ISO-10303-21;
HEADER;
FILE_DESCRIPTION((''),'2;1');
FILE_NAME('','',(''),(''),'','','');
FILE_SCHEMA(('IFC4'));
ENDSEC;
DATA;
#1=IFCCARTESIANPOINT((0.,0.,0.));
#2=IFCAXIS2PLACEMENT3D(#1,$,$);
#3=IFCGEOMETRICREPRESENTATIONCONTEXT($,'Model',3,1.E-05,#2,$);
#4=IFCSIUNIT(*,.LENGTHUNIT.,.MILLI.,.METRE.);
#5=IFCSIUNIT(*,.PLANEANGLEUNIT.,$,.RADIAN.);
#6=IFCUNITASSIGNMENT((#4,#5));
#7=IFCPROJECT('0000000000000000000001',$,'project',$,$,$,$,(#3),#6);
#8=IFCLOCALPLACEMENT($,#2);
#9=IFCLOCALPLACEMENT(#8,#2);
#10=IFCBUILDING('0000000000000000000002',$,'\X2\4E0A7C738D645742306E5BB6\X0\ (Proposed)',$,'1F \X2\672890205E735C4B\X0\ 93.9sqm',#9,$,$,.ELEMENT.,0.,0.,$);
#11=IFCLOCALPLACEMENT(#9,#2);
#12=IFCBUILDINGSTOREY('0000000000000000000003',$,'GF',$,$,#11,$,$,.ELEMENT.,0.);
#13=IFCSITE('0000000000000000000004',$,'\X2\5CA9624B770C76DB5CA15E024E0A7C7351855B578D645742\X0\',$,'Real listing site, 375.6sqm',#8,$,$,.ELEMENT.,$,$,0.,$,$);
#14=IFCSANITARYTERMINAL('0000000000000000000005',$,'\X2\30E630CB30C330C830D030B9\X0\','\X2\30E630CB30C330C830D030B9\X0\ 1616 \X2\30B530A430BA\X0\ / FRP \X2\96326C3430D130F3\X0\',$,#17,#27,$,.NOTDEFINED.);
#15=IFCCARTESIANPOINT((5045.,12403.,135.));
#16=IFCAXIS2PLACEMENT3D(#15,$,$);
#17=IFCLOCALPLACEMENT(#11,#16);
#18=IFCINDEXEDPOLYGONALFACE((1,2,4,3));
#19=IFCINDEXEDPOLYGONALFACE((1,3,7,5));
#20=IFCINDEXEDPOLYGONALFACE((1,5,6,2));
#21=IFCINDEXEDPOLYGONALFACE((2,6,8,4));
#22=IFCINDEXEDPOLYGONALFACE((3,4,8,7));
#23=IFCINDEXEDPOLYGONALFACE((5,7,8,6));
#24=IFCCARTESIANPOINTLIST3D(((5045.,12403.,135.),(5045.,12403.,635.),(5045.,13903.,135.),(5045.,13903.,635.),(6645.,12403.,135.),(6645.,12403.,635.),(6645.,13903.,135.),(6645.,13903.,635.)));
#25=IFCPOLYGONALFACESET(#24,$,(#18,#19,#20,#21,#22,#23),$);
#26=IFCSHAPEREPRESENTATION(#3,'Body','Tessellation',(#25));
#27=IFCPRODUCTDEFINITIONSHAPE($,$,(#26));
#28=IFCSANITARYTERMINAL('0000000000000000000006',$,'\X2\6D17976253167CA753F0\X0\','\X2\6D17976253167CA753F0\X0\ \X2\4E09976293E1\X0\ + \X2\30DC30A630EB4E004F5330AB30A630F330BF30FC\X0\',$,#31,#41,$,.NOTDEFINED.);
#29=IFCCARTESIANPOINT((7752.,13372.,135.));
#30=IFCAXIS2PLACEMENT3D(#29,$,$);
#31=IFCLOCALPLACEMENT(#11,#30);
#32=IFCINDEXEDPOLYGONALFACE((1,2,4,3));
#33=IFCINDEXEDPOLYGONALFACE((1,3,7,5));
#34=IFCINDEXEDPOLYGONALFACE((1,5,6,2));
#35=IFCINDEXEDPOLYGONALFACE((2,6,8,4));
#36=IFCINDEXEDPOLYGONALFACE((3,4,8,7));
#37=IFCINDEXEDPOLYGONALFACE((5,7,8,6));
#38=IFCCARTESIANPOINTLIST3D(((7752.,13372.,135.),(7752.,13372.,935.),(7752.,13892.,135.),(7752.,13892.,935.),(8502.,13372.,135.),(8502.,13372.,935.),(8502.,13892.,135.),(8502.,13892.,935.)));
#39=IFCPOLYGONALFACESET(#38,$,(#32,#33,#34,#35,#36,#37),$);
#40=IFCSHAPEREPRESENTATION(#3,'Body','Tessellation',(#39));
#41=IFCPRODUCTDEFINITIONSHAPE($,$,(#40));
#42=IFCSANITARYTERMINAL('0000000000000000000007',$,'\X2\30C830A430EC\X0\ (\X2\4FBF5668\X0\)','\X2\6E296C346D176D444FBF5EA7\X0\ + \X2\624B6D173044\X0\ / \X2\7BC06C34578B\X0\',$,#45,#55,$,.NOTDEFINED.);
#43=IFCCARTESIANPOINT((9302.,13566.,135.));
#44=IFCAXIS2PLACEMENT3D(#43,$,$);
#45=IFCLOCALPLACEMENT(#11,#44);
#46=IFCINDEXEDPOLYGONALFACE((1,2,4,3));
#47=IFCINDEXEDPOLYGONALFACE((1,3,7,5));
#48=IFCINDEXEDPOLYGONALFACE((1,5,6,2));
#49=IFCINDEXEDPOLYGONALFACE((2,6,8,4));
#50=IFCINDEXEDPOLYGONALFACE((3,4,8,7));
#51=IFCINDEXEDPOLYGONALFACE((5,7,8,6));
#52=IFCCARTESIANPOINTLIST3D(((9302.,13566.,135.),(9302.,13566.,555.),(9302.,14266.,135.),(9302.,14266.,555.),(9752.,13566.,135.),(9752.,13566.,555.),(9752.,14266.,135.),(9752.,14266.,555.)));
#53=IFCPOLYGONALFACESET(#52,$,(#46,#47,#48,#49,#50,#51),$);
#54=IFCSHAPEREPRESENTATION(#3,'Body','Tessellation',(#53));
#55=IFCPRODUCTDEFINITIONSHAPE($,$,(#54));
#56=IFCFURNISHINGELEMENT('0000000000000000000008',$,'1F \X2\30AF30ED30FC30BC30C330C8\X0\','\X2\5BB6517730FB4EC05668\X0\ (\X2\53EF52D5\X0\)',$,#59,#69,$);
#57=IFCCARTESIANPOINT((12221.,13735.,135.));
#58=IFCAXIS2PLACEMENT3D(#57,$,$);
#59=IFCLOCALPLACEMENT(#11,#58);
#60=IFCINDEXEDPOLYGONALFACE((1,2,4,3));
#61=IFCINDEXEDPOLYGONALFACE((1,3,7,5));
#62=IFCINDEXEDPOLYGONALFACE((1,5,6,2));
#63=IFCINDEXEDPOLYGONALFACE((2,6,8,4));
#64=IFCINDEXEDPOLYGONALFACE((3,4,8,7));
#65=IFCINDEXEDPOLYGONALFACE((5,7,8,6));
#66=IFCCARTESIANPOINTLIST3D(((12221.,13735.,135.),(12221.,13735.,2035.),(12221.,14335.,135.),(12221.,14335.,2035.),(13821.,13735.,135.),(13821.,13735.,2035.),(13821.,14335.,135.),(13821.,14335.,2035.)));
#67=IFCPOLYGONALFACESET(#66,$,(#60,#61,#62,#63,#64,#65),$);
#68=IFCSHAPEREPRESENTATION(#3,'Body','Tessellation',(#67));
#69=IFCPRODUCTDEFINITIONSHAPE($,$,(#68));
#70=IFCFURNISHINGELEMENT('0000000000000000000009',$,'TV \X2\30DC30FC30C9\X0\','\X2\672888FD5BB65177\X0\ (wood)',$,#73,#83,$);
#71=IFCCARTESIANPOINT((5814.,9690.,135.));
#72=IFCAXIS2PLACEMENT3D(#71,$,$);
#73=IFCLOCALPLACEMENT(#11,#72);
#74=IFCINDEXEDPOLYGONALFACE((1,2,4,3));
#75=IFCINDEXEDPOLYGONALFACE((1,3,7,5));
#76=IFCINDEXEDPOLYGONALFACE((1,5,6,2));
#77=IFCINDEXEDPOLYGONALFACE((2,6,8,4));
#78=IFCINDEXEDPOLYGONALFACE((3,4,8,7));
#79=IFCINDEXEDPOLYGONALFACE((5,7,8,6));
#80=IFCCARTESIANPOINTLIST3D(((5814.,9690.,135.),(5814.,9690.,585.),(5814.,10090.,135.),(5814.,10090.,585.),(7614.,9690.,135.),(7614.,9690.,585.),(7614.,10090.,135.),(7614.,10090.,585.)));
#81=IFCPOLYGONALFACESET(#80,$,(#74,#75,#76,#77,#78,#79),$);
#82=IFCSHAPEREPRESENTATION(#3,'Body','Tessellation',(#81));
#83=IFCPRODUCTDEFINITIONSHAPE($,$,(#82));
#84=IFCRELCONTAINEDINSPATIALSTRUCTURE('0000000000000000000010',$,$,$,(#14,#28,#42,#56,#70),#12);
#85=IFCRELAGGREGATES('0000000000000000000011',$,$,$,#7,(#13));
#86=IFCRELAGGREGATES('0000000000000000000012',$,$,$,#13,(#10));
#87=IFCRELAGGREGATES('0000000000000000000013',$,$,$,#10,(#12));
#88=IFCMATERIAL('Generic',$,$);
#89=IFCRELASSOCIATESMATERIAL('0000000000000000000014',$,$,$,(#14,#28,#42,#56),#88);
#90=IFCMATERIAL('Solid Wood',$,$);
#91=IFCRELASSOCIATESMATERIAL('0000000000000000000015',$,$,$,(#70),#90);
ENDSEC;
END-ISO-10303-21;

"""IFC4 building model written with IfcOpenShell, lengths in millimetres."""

from ifc_helpers import new_model, si_unit, frame, frame_2d, origin, place, context, project, spatial, rectangle, extrude, material, element, save


model = new_model("IFC4")

# Units and contexts
model_context = context("Model", 3, precision=1e-05, world=origin())
ifc_project = project(units=[si_unit("LENGTHUNIT", "METRE", prefix="MILLI"), si_unit("PLANEANGLEUNIT", "RADIAN")], contexts=[model_context])

# Site, building, storey
site_placement = place(None, origin())
site = spatial("IfcSite", under=ifc_project, at=site_placement, Name="岩手県盛岡市上米内字赤坂", ObjectType="Real listing site, 375.6sqm", CompositionType="ELEMENT", RefElevation=0.0)
building_placement = place(site_placement, origin())
building = spatial("IfcBuilding", under=site, at=building_placement, Name="上米赤坂の家 (Proposed)", ObjectType="1F 木造平屋 93.9sqm", CompositionType="ELEMENT", ElevationOfRefHeight=0.0, ElevationOfTerrain=0.0)
storey_placement = place(building_placement, origin())
storey = spatial("IfcBuildingStorey", under=building, at=storey_placement, Name="GF", CompositionType="ELEMENT", Elevation=0.0)

# Shared definitions
ifc_material_1 = material(Name="Solid Wood")

# Sanitary terminals
ifc_material_2 = material(Name="Generic")
sanitary_terminal_1_placement = place(storey_placement, frame((5045.0, 12403.0, 135.0)))
element("IfcSanitaryTerminal", 1, at=sanitary_terminal_1_placement, inside=storey, material=ifc_material_2, Name="ユニットバス", Description="ユニットバス 1616 サイズ / FRP 防水パン", PredefinedType="NOTDEFINED", context=model_context, shape_type="SweptSolid", body=[
    extrude(rectangle(XDim=1600.0, YDim=1500.0, at=frame_2d((800.0, 750.0))), frame((5045.0, 12403.0, 135.0)), (0.0, 0.0, 1.0), 500.0),
])
sanitary_terminal_2_placement = place(storey_placement, frame((7752.0, 13372.0, 135.0)))
element("IfcSanitaryTerminal", 2, at=sanitary_terminal_2_placement, inside=storey, material=ifc_material_2, Name="洗面化粧台", Description="洗面化粧台 三面鏡 + ボウル一体カウンター", PredefinedType="NOTDEFINED", context=model_context, shape_type="SweptSolid", body=[
    extrude(rectangle(XDim=750.0, YDim=520.0, at=frame_2d((375.0, 260.0))), frame((7752.0, 13372.0, 135.0)), (0.0, 0.0, 1.0), 800.0),
])
sanitary_terminal_3_placement = place(storey_placement, frame((9302.0, 13566.0, 135.0)))
element("IfcSanitaryTerminal", 3, at=sanitary_terminal_3_placement, inside=storey, material=ifc_material_2, Name="トイレ (便器)", Description="温水洗浄便座 + 手洗い / 節水型", PredefinedType="NOTDEFINED", context=model_context, shape_type="SweptSolid", body=[
    extrude(rectangle(XDim=450.0, YDim=700.0, at=frame_2d((225.0, 350.0))), frame((9302.0, 13566.0, 135.0)), (0.0, 0.0, 1.0), 420.0),
])

# Furnishing elements
furnishing_1_placement = place(storey_placement, frame((12221.0, 13735.0, 135.0)))
element("IfcFurnishingElement", 4, at=furnishing_1_placement, inside=storey, material=ifc_material_2, Name="1F クローゼット", Description="家具・什器 (可動)", context=model_context, shape_type="SweptSolid", body=[
    extrude(rectangle(XDim=1600.0, YDim=600.0, at=frame_2d((800.0, 300.0))), frame((12221.0, 13735.0, 135.0)), (0.0, 0.0, 1.0), 1900.0),
])
furnishing_2_placement = place(storey_placement, frame((5814.0, 9690.0, 135.0)))
element("IfcFurnishingElement", 5, at=furnishing_2_placement, inside=storey, material=ifc_material_1, Name="TV ボード", Description="木製家具 (wood)", context=model_context, shape_type="SweptSolid", body=[
    extrude(rectangle(XDim=1800.0, YDim=400.0, at=frame_2d((900.0, 200.0))), frame((5814.0, 9690.0, 135.0)), (0.0, 0.0, 1.0), 450.0),
])

save(model, "model.ifc")
